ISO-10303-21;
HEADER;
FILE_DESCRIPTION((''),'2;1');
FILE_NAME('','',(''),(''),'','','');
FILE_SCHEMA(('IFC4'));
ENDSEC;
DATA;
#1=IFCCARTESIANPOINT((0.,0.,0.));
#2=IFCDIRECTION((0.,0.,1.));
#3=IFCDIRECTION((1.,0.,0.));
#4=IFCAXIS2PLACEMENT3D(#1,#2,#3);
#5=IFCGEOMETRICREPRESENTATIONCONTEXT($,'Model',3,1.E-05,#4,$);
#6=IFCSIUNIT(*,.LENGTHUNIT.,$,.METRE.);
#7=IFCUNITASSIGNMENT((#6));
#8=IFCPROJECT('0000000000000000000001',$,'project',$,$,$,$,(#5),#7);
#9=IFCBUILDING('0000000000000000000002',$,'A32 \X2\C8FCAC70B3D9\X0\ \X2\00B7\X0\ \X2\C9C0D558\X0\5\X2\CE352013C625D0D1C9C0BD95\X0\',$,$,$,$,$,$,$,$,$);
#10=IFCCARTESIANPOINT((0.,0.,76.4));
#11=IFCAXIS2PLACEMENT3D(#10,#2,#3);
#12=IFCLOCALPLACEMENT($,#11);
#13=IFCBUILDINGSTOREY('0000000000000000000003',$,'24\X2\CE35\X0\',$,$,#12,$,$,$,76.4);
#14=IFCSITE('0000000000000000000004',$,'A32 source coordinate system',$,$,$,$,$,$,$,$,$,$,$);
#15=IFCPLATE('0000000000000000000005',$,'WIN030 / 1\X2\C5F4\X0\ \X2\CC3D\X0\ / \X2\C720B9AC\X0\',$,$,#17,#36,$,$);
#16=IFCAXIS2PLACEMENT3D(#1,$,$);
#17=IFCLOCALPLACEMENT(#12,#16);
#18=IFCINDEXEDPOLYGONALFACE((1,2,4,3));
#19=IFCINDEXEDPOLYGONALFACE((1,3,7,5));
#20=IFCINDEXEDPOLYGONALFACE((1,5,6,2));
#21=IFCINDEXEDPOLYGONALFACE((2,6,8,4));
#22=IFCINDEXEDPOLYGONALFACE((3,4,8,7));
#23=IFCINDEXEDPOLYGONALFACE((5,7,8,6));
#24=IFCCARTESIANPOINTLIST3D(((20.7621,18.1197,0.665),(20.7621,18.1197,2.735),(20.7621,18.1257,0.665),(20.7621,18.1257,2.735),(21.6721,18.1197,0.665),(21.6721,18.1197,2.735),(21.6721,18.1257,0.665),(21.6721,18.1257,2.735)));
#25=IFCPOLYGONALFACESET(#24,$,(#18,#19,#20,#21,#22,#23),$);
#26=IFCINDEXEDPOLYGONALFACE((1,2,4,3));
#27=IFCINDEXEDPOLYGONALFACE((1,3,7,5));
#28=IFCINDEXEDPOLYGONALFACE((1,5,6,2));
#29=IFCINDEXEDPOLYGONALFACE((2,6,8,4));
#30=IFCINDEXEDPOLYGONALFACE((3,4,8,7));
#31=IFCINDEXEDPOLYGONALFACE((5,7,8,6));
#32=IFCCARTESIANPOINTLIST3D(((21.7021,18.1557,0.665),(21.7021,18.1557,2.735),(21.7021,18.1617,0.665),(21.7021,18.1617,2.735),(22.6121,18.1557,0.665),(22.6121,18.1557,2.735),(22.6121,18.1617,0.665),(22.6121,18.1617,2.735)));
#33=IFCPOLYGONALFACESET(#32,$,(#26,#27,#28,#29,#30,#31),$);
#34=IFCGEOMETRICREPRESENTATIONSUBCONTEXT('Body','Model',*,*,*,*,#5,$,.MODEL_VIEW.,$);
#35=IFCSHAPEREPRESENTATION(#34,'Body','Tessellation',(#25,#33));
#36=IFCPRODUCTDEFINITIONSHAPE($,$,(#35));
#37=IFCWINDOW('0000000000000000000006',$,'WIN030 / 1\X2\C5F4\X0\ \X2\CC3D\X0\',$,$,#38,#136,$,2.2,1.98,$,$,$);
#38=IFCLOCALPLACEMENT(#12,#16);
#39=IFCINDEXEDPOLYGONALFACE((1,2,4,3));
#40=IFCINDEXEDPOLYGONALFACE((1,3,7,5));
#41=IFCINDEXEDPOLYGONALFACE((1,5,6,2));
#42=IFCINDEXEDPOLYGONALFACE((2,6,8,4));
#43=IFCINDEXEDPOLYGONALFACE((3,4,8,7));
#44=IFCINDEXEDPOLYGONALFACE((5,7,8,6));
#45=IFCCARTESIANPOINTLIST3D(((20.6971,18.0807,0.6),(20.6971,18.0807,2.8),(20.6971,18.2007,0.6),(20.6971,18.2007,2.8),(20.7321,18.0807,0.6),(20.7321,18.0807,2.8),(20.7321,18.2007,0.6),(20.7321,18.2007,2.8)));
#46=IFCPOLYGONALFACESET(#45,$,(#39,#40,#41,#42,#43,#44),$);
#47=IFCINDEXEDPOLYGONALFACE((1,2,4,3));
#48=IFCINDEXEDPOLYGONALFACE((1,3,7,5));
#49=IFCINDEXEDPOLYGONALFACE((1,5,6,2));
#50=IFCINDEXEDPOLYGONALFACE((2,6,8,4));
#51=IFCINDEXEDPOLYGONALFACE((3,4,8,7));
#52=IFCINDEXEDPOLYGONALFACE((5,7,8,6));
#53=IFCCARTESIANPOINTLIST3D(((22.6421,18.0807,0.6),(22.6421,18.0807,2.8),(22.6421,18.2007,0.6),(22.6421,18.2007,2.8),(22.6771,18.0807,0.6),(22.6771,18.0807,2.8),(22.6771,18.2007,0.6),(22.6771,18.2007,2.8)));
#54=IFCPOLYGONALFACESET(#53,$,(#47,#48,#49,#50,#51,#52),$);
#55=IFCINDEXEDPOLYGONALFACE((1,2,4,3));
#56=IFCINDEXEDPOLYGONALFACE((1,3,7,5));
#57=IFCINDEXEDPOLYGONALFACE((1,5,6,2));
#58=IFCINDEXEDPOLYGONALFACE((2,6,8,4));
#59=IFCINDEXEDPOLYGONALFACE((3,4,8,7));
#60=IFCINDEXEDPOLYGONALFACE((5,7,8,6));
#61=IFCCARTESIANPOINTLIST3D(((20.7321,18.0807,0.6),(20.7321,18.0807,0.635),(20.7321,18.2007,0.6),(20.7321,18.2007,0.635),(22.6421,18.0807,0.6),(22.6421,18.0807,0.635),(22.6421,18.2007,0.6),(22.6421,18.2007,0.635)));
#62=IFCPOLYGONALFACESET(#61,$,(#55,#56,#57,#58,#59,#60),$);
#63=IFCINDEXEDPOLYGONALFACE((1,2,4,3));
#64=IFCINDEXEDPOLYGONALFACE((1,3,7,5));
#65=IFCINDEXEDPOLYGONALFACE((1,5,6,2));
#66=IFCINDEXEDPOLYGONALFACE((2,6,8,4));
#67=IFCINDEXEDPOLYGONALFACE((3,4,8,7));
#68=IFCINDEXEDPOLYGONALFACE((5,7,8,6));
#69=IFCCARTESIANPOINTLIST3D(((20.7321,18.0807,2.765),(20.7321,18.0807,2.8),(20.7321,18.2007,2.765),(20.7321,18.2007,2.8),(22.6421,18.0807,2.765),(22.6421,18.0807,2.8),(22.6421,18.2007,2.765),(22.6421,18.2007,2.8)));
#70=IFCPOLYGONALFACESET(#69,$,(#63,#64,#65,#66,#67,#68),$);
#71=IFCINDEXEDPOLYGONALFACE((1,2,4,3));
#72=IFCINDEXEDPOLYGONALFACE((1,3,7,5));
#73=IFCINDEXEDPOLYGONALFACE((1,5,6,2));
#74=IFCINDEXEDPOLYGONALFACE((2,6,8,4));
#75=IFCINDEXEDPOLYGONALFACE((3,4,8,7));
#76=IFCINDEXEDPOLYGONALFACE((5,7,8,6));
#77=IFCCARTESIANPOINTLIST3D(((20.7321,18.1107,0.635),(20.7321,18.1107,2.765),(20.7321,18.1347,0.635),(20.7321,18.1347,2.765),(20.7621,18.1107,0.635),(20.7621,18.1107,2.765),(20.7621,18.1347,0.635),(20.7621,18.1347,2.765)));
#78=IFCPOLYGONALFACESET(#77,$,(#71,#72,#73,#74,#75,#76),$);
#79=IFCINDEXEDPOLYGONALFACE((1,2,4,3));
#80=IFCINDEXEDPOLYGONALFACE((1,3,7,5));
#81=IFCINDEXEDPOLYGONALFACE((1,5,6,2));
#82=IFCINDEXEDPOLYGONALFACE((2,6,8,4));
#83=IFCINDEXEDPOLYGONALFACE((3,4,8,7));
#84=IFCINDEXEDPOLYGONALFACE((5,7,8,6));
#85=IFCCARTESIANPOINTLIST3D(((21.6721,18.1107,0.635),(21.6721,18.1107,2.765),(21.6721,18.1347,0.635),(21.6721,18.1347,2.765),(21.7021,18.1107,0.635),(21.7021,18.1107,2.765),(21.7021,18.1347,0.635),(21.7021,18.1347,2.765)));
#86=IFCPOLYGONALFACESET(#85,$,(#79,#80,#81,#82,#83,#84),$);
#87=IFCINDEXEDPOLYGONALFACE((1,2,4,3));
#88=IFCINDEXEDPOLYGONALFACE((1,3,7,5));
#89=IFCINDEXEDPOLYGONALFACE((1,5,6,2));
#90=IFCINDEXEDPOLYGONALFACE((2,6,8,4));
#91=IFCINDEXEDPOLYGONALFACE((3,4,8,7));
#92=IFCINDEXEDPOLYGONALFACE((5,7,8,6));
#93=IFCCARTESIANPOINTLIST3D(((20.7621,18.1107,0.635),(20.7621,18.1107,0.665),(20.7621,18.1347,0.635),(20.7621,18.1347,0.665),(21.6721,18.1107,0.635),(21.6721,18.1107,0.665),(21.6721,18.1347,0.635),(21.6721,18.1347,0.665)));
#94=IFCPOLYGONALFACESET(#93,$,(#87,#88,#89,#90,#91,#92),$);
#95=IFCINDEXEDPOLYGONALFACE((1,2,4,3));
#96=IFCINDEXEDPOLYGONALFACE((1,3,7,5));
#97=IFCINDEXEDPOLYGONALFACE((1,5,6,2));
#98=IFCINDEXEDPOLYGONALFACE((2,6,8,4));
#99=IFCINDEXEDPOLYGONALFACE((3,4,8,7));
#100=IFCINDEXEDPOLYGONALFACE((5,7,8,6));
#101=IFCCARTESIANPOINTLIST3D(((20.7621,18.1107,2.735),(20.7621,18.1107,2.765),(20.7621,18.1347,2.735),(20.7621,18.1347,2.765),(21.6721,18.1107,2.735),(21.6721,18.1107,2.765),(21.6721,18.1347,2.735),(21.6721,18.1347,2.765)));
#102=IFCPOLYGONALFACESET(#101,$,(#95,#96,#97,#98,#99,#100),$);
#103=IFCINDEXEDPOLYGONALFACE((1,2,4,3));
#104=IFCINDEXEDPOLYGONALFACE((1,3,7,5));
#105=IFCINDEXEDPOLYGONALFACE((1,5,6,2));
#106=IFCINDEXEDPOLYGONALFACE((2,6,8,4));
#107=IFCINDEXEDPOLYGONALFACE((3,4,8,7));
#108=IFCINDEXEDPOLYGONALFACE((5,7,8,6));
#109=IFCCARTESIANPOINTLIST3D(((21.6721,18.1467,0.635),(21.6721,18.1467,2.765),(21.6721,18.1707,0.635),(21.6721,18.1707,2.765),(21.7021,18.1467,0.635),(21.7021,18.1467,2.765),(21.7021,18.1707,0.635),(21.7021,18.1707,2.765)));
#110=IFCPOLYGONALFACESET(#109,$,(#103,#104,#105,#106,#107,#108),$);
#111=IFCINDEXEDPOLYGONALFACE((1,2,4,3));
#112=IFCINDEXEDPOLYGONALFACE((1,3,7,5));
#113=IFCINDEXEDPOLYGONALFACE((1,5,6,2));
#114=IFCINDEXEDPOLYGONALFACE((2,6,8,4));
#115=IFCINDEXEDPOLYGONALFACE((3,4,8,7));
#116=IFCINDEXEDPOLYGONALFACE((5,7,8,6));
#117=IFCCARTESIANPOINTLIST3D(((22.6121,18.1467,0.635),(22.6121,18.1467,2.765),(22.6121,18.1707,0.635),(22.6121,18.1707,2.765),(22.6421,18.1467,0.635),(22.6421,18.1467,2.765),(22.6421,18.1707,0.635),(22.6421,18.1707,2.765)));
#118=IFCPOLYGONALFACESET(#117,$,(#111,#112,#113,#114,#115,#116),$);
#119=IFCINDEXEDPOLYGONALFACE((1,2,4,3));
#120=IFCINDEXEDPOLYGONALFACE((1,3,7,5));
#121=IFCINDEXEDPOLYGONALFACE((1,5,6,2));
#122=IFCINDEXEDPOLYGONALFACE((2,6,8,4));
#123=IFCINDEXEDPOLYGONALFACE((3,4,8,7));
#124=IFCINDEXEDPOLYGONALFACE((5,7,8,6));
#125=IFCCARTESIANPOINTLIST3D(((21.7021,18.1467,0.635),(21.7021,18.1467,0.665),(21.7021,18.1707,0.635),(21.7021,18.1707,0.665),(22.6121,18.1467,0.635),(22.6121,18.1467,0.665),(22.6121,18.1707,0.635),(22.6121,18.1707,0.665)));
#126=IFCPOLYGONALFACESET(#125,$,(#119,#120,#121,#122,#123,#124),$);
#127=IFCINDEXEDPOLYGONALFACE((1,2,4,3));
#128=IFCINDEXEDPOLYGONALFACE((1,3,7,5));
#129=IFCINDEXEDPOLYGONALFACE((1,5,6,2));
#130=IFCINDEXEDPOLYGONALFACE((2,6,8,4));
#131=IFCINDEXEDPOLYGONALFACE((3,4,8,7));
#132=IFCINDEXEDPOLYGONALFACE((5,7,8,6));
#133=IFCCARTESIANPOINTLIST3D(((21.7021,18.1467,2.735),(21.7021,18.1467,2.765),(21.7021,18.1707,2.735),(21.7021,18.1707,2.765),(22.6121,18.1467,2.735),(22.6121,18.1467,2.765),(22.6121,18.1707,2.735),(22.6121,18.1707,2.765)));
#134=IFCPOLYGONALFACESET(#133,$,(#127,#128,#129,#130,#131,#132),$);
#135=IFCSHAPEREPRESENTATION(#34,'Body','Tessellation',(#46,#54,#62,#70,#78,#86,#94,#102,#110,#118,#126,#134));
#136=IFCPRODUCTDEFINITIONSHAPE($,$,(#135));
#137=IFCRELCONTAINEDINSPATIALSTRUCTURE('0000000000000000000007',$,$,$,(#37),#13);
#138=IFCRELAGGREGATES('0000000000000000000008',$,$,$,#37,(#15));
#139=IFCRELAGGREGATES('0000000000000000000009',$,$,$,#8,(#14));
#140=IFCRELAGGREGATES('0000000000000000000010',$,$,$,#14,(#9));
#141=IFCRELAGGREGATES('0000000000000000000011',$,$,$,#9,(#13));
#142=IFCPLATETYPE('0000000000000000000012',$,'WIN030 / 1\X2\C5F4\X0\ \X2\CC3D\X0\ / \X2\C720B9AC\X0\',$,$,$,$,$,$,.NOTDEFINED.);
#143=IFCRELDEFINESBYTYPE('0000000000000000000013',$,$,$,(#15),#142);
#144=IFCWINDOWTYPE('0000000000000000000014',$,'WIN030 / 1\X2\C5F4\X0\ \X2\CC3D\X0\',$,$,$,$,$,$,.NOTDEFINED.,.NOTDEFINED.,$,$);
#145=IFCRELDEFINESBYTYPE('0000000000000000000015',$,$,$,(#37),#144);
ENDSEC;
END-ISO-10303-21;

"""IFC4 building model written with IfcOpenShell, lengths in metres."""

from ifc_helpers import new_model, si_unit, frame, origin, origin_with_axes, place, context, subcontext, project, spatial, polyline, outline, extrude, source, transform, mapped, type_object, type_shapes, element, aggregate, save


model = new_model("IFC4")

# Units and contexts
model_context = context("Model", 3, precision=1e-05, world=origin_with_axes())
body_context = subcontext(model_context, "Body", "Model", "MODEL_VIEW")
ifc_project = project(units=[si_unit("LENGTHUNIT", "METRE")], contexts=[model_context])

# Site, building, storey
site = spatial("IfcSite", under=ifc_project, Name="A32 source coordinate system")
building = spatial("IfcBuilding", under=site, Name="A32 주거동 · 지하5층–옥탑지붕")
storey_placement = place(None, frame((0.0, 0.0, 76.4), z_axis=(0.0, 0.0, 1.0), x_axis=(1.0, 0.0, 0.0)))
storey = spatial("IfcBuildingStorey", under=building, at=storey_placement, Name="24층", Elevation=76.4)

# Plate
plate_type_1 = type_object("IfcPlateType", Name="WIN030 / 1열 창 / 유리", PredefinedType="NOTDEFINED")
shared_shape_1 = source(origin(), body_context, "Body", "SweptSolid", [
    extrude(outline(polyline([(20.7621, 18.1197), (20.7621, 18.1257), (21.6721, 18.1257), (21.6721, 18.1197), (20.7621, 18.1197)])), frame((0.0, 0.0, 0.665)), (0.0, 0.0, 1.0), 2.07),
    extrude(outline(polyline([(21.7021, 18.1557), (21.7021, 18.1617), (22.6121, 18.1617), (22.6121, 18.1557), (21.7021, 18.1557)])), frame((0.0, 0.0, 0.665)), (0.0, 0.0, 1.0), 2.07),
])
type_shapes(plate_type_1, [shared_shape_1])
window_1_placement = place(storey_placement, origin_with_axes())
plate_1_placement = place(window_1_placement, origin_with_axes())
plate_1 = element("IfcPlate", 1, at=plate_1_placement, type_object=plate_type_1, Name="WIN030 / 1열 창 / 유리", context=body_context, shape_type="MappedRepresentation", body=[
    mapped(shared_shape_1, transform((0.0, 0.0, 0.0), scale=1.0)),
])

# Window
window_type_1 = type_object("IfcWindowType", Name="WIN030 / 1열 창", PartitioningType="NOTDEFINED", PredefinedType="NOTDEFINED")
shared_shape_2 = source(origin(), body_context, "Body", "SweptSolid", [
    extrude(outline(polyline([(20.6971, 18.0807), (20.6971, 18.2007), (20.7321, 18.2007), (20.7321, 18.0807), (20.6971, 18.0807)])), frame((0.0, 0.0, 0.6)), (0.0, 0.0, 1.0), 2.2),
    extrude(outline(polyline([(22.6421, 18.0807), (22.6421, 18.2007), (22.6771, 18.2007), (22.6771, 18.0807), (22.6421, 18.0807)])), frame((0.0, 0.0, 0.6)), (0.0, 0.0, 1.0), 2.2),
    extrude(outline(polyline([(20.7321, 18.0807), (20.7321, 18.2007), (22.6421, 18.2007), (22.6421, 18.0807), (20.7321, 18.0807)])), frame((0.0, 0.0, 0.6)), (0.0, 0.0, 1.0), 0.035),
    extrude(outline(polyline([(20.7321, 18.0807), (20.7321, 18.2007), (22.6421, 18.2007), (22.6421, 18.0807), (20.7321, 18.0807)])), frame((0.0, 0.0, 2.765)), (0.0, 0.0, 1.0), 0.035),
    extrude(outline(polyline([(20.7321, 18.1107), (20.7321, 18.1347), (20.7621, 18.1347), (20.7621, 18.1107), (20.7321, 18.1107)])), frame((0.0, 0.0, 0.635)), (0.0, 0.0, 1.0), 2.13),
    extrude(outline(polyline([(21.6721, 18.1107), (21.6721, 18.1347), (21.7021, 18.1347), (21.7021, 18.1107), (21.6721, 18.1107)])), frame((0.0, 0.0, 0.635)), (0.0, 0.0, 1.0), 2.13),
    extrude(outline(polyline([(20.7621, 18.1107), (20.7621, 18.1347), (21.6721, 18.1347), (21.6721, 18.1107), (20.7621, 18.1107)])), frame((0.0, 0.0, 0.635)), (0.0, 0.0, 1.0), 0.03),
    extrude(outline(polyline([(20.7621, 18.1107), (20.7621, 18.1347), (21.6721, 18.1347), (21.6721, 18.1107), (20.7621, 18.1107)])), frame((0.0, 0.0, 2.735)), (0.0, 0.0, 1.0), 0.03),
    extrude(outline(polyline([(21.6721, 18.1467), (21.6721, 18.1707), (21.7021, 18.1707), (21.7021, 18.1467), (21.6721, 18.1467)])), frame((0.0, 0.0, 0.635)), (0.0, 0.0, 1.0), 2.13),
    extrude(outline(polyline([(22.6121, 18.1467), (22.6121, 18.1707), (22.6421, 18.1707), (22.6421, 18.1467), (22.6121, 18.1467)])), frame((0.0, 0.0, 0.635)), (0.0, 0.0, 1.0), 2.13),
    extrude(outline(polyline([(21.7021, 18.1467), (21.7021, 18.1707), (22.6121, 18.1707), (22.6121, 18.1467), (21.7021, 18.1467)])), frame((0.0, 0.0, 0.635)), (0.0, 0.0, 1.0), 0.03),
    extrude(outline(polyline([(21.7021, 18.1467), (21.7021, 18.1707), (22.6121, 18.1707), (22.6121, 18.1467), (21.7021, 18.1467)])), frame((0.0, 0.0, 2.735)), (0.0, 0.0, 1.0), 0.03),
])
type_shapes(window_type_1, [shared_shape_2])
window_1 = element("IfcWindow", 2, at=window_1_placement, inside=storey, type_object=window_type_1, Name="WIN030 / 1열 창", OverallHeight=2.2, OverallWidth=1.98, context=body_context, shape_type="MappedRepresentation", body=[
    mapped(shared_shape_2, transform((0.0, 0.0, 0.0), scale=1.0)),
])
aggregate(window_1, [plate_1])

save(model, "model.ifc")
